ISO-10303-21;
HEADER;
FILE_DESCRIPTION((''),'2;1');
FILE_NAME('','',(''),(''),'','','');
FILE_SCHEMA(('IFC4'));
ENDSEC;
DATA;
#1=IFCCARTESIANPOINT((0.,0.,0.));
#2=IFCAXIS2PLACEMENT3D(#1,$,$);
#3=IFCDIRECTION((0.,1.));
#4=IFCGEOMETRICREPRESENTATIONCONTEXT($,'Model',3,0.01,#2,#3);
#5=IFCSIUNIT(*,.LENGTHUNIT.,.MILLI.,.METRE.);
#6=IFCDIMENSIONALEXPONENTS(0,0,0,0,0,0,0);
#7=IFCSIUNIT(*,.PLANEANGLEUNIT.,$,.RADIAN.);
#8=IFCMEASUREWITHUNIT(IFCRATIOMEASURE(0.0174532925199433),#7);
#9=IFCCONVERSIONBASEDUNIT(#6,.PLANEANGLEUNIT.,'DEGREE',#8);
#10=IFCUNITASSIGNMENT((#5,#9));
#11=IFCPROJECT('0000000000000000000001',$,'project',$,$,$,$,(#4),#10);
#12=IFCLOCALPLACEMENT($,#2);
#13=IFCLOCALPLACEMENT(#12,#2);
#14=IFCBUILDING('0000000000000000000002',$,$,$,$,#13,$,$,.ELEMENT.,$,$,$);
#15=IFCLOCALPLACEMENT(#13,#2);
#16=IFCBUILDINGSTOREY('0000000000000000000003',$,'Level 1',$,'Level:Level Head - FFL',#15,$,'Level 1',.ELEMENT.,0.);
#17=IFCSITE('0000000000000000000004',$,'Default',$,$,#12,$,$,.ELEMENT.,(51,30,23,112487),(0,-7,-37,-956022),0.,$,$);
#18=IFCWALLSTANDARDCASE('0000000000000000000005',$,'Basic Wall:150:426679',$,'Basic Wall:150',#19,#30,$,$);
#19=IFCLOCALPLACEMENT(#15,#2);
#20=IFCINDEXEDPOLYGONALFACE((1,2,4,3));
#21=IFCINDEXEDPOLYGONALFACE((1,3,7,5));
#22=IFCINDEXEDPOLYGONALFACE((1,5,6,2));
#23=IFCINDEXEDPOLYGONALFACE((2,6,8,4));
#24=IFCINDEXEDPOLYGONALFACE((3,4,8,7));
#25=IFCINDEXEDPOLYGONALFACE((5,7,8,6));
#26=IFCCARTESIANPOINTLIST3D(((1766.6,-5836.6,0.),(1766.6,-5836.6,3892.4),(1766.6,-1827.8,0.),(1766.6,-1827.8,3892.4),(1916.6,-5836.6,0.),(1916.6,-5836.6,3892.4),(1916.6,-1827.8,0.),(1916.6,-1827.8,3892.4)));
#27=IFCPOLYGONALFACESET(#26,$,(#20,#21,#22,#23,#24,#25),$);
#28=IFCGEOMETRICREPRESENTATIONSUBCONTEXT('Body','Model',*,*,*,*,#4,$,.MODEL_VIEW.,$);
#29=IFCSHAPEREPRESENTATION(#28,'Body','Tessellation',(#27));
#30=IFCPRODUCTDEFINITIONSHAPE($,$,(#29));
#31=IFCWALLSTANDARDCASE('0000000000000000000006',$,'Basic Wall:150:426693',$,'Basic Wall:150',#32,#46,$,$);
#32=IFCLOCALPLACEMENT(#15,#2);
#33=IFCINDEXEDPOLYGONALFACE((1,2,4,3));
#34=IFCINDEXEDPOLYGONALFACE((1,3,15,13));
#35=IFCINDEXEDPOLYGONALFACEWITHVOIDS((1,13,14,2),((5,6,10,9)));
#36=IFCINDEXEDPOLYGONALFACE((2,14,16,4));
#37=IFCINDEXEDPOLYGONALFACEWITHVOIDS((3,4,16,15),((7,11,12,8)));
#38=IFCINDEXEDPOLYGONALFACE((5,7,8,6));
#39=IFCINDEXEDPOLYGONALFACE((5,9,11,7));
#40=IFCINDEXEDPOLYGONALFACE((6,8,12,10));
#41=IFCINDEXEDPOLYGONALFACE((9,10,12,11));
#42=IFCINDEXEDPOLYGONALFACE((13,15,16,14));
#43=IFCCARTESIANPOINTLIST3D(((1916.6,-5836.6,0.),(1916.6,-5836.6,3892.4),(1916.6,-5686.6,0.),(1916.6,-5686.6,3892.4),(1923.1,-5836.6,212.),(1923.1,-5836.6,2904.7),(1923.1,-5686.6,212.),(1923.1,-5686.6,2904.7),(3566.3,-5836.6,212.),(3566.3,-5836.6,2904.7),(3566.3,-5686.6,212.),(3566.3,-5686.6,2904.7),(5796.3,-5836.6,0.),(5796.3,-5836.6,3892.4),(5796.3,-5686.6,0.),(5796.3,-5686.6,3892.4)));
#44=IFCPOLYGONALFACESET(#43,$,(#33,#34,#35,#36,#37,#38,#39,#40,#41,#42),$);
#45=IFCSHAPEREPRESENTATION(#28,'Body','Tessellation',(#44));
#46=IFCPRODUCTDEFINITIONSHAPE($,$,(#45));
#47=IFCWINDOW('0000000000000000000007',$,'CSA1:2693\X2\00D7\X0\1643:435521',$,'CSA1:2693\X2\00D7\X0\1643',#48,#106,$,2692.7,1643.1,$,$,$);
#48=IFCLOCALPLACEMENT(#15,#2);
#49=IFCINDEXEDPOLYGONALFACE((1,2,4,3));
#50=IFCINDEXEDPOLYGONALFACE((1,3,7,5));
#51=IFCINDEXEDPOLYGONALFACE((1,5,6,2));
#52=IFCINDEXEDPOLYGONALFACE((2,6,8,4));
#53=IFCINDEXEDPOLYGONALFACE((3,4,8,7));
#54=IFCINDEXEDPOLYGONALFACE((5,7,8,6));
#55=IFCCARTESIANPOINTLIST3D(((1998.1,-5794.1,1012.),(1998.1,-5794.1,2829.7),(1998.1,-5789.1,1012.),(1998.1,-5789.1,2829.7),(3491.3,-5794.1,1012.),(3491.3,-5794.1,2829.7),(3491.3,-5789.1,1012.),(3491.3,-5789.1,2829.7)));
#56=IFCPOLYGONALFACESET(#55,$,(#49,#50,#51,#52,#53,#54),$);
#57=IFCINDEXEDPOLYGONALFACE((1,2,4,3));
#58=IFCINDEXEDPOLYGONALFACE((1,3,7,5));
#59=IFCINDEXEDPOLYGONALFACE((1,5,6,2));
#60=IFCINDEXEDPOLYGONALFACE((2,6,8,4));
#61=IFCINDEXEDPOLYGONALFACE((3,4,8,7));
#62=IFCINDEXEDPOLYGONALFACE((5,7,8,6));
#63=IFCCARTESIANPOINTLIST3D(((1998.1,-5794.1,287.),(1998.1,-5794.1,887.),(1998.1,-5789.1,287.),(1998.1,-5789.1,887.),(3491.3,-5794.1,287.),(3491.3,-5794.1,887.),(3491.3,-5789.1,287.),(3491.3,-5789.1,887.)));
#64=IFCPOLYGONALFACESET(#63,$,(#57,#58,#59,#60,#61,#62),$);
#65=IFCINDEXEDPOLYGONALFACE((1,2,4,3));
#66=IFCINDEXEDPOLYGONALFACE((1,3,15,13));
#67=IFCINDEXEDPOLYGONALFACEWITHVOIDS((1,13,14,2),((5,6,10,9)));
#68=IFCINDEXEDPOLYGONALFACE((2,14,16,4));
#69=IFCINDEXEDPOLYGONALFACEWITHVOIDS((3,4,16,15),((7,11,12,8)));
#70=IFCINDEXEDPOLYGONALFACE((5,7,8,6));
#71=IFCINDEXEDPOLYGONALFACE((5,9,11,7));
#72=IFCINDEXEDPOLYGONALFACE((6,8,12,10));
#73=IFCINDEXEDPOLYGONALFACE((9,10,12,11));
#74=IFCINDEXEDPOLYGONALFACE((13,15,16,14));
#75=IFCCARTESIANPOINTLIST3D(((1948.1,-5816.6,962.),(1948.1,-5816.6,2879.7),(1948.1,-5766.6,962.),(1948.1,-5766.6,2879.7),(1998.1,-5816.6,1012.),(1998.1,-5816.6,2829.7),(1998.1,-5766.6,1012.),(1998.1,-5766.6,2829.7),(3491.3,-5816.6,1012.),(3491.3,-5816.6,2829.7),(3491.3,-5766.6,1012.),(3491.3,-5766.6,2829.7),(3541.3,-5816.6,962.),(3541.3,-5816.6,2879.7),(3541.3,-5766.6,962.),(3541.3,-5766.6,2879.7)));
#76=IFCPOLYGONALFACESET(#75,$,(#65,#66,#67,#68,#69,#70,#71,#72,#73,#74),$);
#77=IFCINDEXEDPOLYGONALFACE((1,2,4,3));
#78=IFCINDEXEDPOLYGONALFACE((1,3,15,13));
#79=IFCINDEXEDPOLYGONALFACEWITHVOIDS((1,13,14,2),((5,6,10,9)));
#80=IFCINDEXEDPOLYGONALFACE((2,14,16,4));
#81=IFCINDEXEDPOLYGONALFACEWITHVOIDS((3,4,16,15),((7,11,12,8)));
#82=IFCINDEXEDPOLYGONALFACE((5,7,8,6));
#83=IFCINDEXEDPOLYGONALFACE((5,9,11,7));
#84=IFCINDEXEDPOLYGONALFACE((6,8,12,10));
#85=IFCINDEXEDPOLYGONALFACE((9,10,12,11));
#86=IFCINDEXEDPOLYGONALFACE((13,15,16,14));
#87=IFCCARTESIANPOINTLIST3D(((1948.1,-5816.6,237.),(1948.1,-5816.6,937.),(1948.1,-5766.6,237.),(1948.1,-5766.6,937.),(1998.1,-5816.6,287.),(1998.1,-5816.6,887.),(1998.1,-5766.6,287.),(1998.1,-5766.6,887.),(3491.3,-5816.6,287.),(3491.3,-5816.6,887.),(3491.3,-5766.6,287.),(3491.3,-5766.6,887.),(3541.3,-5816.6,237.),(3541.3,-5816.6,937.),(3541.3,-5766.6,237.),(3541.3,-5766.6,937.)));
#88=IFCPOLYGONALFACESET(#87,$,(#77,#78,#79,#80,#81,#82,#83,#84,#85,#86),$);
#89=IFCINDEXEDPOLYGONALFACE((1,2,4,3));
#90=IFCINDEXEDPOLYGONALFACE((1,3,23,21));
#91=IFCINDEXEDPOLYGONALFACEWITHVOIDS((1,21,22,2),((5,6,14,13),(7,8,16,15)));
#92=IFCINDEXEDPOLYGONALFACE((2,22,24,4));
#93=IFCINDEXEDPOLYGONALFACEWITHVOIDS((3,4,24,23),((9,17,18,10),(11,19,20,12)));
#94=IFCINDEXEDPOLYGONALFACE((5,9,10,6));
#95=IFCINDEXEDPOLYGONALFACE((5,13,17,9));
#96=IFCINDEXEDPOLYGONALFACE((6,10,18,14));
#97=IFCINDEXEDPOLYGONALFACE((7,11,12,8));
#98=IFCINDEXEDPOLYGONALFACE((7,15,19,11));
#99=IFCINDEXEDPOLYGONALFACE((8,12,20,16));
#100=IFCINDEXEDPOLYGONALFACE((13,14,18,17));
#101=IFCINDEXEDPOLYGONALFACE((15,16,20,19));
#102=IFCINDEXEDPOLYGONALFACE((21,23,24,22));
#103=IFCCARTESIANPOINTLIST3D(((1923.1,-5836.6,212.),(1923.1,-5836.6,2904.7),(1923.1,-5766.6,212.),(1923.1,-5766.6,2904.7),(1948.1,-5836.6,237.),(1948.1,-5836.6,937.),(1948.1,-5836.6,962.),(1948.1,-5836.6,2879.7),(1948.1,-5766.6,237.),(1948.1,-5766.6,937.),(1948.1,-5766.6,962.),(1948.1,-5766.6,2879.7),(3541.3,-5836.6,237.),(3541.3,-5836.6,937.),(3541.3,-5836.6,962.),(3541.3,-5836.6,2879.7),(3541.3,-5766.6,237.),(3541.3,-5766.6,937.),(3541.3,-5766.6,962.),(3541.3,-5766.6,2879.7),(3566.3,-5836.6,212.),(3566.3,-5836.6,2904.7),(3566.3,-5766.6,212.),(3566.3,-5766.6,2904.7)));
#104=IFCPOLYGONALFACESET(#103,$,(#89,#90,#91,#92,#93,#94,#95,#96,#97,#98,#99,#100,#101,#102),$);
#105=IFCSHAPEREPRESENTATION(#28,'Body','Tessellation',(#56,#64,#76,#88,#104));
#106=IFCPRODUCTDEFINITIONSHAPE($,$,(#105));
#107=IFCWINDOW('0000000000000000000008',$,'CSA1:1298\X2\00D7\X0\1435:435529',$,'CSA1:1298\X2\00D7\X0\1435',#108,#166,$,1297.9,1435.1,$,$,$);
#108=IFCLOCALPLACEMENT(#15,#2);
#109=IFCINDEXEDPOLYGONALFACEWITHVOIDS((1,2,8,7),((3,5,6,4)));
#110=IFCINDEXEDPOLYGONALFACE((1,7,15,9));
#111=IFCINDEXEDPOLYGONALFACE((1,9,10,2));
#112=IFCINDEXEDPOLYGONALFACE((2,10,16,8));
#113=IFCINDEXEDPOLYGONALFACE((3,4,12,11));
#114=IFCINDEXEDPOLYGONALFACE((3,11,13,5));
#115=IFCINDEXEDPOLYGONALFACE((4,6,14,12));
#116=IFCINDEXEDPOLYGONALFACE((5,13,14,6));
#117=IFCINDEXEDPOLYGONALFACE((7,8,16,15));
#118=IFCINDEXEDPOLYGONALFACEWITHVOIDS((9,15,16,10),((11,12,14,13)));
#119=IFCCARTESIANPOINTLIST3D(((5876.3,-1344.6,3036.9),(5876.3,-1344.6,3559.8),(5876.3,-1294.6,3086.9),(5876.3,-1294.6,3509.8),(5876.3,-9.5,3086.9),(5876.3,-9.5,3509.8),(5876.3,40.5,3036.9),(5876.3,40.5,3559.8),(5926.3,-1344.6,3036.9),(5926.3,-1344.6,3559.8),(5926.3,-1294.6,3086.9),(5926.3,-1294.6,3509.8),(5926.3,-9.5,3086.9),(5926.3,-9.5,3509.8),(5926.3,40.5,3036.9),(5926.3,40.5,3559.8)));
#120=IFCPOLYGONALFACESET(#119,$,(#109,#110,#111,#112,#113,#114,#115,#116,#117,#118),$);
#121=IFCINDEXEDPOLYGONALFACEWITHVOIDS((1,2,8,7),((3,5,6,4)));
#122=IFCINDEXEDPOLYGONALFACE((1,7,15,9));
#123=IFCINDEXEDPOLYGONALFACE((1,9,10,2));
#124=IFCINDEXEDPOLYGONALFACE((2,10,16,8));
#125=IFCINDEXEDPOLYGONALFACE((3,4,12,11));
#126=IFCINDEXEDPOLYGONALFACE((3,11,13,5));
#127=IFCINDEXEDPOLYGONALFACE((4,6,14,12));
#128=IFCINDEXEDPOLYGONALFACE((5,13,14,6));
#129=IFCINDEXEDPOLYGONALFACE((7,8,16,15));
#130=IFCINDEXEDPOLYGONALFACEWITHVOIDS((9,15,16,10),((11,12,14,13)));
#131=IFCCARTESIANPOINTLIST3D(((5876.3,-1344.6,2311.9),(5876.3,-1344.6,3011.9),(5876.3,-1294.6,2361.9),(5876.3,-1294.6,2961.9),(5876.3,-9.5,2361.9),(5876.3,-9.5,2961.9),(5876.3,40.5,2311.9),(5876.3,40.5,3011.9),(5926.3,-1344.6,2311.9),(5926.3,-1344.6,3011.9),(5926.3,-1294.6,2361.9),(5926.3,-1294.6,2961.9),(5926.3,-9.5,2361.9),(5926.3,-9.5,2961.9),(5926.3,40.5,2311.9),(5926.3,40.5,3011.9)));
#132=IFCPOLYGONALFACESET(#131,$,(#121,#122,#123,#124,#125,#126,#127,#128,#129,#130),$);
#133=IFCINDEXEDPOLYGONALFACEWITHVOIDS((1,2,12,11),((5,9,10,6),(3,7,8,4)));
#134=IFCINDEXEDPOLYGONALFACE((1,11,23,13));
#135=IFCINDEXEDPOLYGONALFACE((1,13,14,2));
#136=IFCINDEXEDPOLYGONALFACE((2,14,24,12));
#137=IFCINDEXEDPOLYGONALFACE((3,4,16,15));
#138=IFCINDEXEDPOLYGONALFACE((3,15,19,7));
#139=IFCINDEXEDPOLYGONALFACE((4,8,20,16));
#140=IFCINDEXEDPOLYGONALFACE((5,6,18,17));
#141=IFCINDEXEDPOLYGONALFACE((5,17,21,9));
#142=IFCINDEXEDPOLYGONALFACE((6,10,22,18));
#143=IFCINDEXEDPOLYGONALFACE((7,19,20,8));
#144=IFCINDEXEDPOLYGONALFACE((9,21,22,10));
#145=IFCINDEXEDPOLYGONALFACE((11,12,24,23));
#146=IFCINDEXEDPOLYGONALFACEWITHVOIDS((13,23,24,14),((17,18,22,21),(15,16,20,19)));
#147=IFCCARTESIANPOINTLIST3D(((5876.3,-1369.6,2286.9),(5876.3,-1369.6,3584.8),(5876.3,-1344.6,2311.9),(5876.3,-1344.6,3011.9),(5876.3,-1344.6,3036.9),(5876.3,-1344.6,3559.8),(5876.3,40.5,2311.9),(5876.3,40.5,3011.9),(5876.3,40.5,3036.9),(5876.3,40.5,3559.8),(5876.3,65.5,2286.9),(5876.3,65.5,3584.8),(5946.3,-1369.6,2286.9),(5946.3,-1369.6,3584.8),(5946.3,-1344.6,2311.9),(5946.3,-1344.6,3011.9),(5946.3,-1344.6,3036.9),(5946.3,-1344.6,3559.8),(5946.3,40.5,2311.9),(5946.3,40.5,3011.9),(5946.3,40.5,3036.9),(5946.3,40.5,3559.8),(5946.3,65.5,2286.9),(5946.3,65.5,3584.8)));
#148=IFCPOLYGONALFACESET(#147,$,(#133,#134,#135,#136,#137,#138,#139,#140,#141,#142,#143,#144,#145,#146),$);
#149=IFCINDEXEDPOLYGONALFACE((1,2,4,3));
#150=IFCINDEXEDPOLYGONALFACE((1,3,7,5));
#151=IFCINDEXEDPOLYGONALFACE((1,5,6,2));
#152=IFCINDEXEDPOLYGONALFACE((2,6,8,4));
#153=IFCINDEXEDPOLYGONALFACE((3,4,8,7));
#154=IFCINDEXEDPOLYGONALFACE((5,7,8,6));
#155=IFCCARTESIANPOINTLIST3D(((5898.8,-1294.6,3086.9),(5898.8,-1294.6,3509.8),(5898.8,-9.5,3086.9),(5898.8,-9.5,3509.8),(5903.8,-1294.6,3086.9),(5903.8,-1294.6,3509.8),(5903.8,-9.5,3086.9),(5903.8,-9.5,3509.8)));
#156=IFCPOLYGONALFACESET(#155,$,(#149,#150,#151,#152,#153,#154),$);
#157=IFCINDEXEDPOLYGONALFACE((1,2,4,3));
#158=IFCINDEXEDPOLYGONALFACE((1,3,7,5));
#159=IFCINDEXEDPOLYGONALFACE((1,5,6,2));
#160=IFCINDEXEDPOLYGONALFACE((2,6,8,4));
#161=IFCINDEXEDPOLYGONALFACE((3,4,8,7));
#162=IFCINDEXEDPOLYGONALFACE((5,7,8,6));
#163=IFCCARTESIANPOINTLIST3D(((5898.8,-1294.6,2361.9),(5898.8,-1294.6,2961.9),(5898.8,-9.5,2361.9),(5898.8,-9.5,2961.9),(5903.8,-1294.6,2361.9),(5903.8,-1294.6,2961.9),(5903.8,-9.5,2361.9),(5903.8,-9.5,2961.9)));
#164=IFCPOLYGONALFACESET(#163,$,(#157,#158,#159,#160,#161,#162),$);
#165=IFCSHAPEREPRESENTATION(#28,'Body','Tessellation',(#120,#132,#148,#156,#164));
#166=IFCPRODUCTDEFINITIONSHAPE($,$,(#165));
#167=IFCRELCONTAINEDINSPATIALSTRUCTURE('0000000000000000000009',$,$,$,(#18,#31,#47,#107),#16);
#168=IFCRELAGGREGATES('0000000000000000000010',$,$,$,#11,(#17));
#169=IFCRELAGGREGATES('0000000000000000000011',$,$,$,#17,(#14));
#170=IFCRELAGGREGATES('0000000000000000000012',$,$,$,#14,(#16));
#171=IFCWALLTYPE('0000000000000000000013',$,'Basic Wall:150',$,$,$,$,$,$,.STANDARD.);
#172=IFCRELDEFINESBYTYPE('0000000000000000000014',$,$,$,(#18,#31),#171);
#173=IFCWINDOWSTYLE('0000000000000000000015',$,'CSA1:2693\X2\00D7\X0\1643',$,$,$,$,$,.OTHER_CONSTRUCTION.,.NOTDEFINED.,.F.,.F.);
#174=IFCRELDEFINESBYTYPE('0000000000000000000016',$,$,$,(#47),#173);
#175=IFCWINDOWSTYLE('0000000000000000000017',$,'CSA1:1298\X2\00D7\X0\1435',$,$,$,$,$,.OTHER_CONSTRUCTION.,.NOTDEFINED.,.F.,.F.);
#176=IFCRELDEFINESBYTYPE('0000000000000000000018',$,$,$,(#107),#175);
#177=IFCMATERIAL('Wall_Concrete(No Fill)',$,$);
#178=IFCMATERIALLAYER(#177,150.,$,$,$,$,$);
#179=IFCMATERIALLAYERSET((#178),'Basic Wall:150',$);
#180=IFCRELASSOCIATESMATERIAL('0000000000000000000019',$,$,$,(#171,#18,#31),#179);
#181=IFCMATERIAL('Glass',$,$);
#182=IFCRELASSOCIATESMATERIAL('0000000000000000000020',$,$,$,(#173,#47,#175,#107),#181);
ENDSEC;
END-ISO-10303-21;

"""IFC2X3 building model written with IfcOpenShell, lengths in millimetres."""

from ifc_helpers import new_model, entity, si_unit, converted_unit, direction, frame, frame_2d, origin, origin_2d_with_axis, place, context, subcontext, project, spatial, polyline, rectangle, outline, extrude, source, transform, mapped, material, layer, layer_set, layer_usage, type_object, type_shapes, element, save


model = new_model("IFC2X3")

# Units and contexts
model_context = context("Model", 3, precision=0.01, world=origin(), true_north=direction((0.0, 1.0)))
body_context = subcontext(model_context, "Body", "Model", "MODEL_VIEW")
ifc_project = project(units=[si_unit("LENGTHUNIT", "METRE", prefix="MILLI"), converted_unit("PLANEANGLEUNIT", "DEGREE", entity("IfcRatioMeasure", 0.0174532925199433), si_unit("PLANEANGLEUNIT", "RADIAN"), dimensions=[0, 0, 0, 0, 0, 0, 0])], contexts=[model_context])

# Site, building, storey
site_placement = place(None, origin())
site = spatial("IfcSite", under=ifc_project, at=site_placement, Name="Default", CompositionType="ELEMENT", RefLatitude=(51, 30, 23, 112487), RefLongitude=(0, -7, -37, -956022), RefElevation=0.0)
building_placement = place(site_placement, origin())
building = spatial("IfcBuilding", under=site, at=building_placement, CompositionType="ELEMENT")
storey_placement = place(building_placement, origin())
storey = spatial("IfcBuildingStorey", under=building, at=storey_placement, Name="Level 1", ObjectType="Level:Level Head - FFL", LongName="Level 1", CompositionType="ELEMENT", Elevation=0.0)

# Wall
ifc_material_1 = material(Name="Wall_Concrete(No Fill)")
ifc_layer = layer(ifc_material_1, 150.0)
ifc_layer_set = layer_set([ifc_layer], Name="Basic Wall:150")
ifc_layer_usage_1 = layer_usage(ifc_layer_set, "AXIS2", "NEGATIVE", 75.0)
wall_type = type_object("IfcWallType", Name="Basic Wall:150", PredefinedType="STANDARD", material=ifc_layer_set)
wall_1_placement = place(storey_placement, frame((1841.6, -5836.6, 0.0), z_axis=(0.0, 0.0, 1.0), x_axis=(0.0, 1.0, 0.0)))
element("IfcWallStandardCase", 1, at=wall_1_placement, inside=storey, type_object=wall_type, material=ifc_layer_usage_1, Name="Basic Wall:150:426679", ObjectType="Basic Wall:150", context=body_context, shape_type="SweptSolid", body=[
    extrude(rectangle(XDim=4008.8, YDim=150.0, at=frame_2d((2004.4, 0.0), x_axis=(-1.0, 0.0))), origin(), (0.0, 0.0, 1.0), 3892.4),
])

# Wall, opening
ifc_layer_usage_2 = layer_usage(ifc_layer_set, "AXIS2", "NEGATIVE", 75.0)
wall_2_placement = place(storey_placement, frame((1916.6, -5761.6, 0.0)))
wall_2 = element("IfcWallStandardCase", 2, at=wall_2_placement, inside=storey, type_object=wall_type, material=ifc_layer_usage_2, Name="Basic Wall:150:426693", ObjectType="Basic Wall:150", context=body_context, shape_type="SweptSolid", body=[
    extrude(rectangle(XDim=3879.7, YDim=150.0, at=frame_2d((1939.9, 0.0), x_axis=(-1.0, 0.0))), origin(), (0.0, 0.0, 1.0), 3892.4),
])
opening_1_placement = place(wall_2_placement, origin())
element("IfcOpeningElement", 3, at=opening_1_placement, cuts=wall_2, ObjectType="Opening", context=body_context, shape_type="SweptSolid", body=[
    extrude(rectangle(XDim=2692.7, YDim=1643.1, at=frame_2d((0.0, 0.0), x_axis=(1.0, 0.0))), frame((828.1, -75.0, 1558.4), z_axis=(0.0, 1.0, 0.0), x_axis=(0.0, 0.0, -1.0)), (0.0, 0.0, 1.0), 150.0),
])

# Windows
ifc_material_2 = material(Name="Glass")
window_style_1 = type_object("IfcWindowStyle", Name="CSA1:2693×1643", ConstructionType="OTHER_CONSTRUCTION", OperationType="NOTDEFINED", ParameterTakesPrecedence=False, Sizeable=False, material=ifc_material_2)
shared_shape_1 = source(origin(), body_context, "Body", "SweptSolid", [
    extrude(rectangle(XDim=5.0, YDim=1493.1, at=origin_2d_with_axis()), frame((821.6, 45.0, 800.0), z_axis=(0.0, 0.0, 1.0), x_axis=(0.0, 1.0, 0.0)), (0.0, 0.0, 1.0), 1817.7),
    extrude(rectangle(XDim=5.0, YDim=1493.1, at=origin_2d_with_axis()), frame((821.6, 45.0, 75.0), z_axis=(0.0, 0.0, 1.0), x_axis=(0.0, 1.0, 0.0)), (0.0, 0.0, 1.0), 600.0),
    extrude(outline(polyline([(-796.6, -958.8), (796.6, -958.8), (796.6, 958.8), (-796.6, 958.8), (-796.6, -958.8)]), holes=[polyline([(-746.6, -908.8), (-746.6, 908.8), (746.6, 908.8), (746.6, -908.8), (-746.6, -908.8)])]), frame((821.6, 20.0, 1708.8), z_axis=(0.0, 1.0, 0.0), x_axis=(1.0, 0.0, 0.0)), (0.0, 0.0, 1.0), 50.0),
    extrude(outline(polyline([(-796.6, -350.0), (796.6, -350.0), (796.6, 350.0), (-796.6, 350.0), (-796.6, -350.0)]), holes=[polyline([(-746.6, -300.0), (-746.6, 300.0), (746.6, 300.0), (746.6, -300.0), (-746.6, -300.0)])]), frame((821.6, 20.0, 375.0), z_axis=(0.0, 1.0, 0.0), x_axis=(1.0, 0.0, 0.0)), (0.0, 0.0, 1.0), 50.0),
    extrude(outline(polyline([(-821.6, -1346.3), (821.6, -1346.3), (821.6, 1346.3), (-821.6, 1346.3), (-821.6, -1346.3)]), holes=[polyline([(-796.6, -1321.3), (-796.6, 596.3), (796.6, 596.3), (796.6, -1321.3), (-796.6, -1321.3)]), polyline([(-796.6, 621.3), (-796.6, 1321.3), (796.6, 1321.3), (796.6, 621.3), (-796.6, 621.3)])]), frame((821.6, 0.0, 1346.3), z_axis=(0.0, 1.0, 0.0), x_axis=(1.0, 0.0, 0.0)), (0.0, 0.0, 1.0), 70.0),
])
type_shapes(window_style_1, [shared_shape_1])
window_1_placement = place(storey_placement, frame((1923.1, -5836.6, 212.0)))
element("IfcWindow", 4, at=window_1_placement, inside=storey, type_object=window_style_1, material=ifc_material_2, Name="CSA1:2693×1643:435521", ObjectType="CSA1:2693×1643", OverallHeight=2692.7, OverallWidth=1643.1, context=body_context, shape_type="MappedRepresentation", body=[
    mapped(shared_shape_1, transform((0.0, 0.0, 0.0), scale=1.0)),
])
window_style_2 = type_object("IfcWindowStyle", Name="CSA1:1298×1435", ConstructionType="OTHER_CONSTRUCTION", OperationType="NOTDEFINED", ParameterTakesPrecedence=False, Sizeable=False, material=ifc_material_2)
shared_shape_2 = source(origin(), body_context, "Body", "SweptSolid", [
    extrude(outline(polyline([(-692.5, -261.4), (692.5, -261.4), (692.5, 261.4), (-692.5, 261.4), (-692.5, -261.4)]), holes=[polyline([(-642.5, -211.4), (-642.5, 211.4), (642.5, 211.4), (642.5, -211.4), (-642.5, -211.4)])]), frame((717.5, 20.0, 1011.4), z_axis=(0.0, 1.0, 0.0), x_axis=(1.0, 0.0, 0.0)), (0.0, 0.0, 1.0), 50.0),
    extrude(outline(polyline([(-692.5, -350.0), (692.5, -350.0), (692.5, 350.0), (-692.5, 350.0), (-692.5, -350.0)]), holes=[polyline([(-642.5, -300.0), (-642.5, 300.0), (642.5, 300.0), (642.5, -300.0), (-642.5, -300.0)])]), frame((717.5, 20.0, 375.0), z_axis=(0.0, 1.0, 0.0), x_axis=(1.0, 0.0, 0.0)), (0.0, 0.0, 1.0), 50.0),
    extrude(outline(polyline([(-717.5, -648.9), (717.5, -648.9), (717.5, 648.9), (-717.5, 648.9), (-717.5, -648.9)]), holes=[polyline([(-692.5, -623.9), (-692.5, -101.1), (692.5, -101.1), (692.5, -623.9), (-692.5, -623.9)]), polyline([(-692.5, -76.1), (-692.5, 623.9), (692.5, 623.9), (692.5, -76.1), (-692.5, -76.1)])]), frame((717.5, 0.0, 648.9), z_axis=(0.0, 1.0, 0.0), x_axis=(1.0, 0.0, 0.0)), (0.0, 0.0, 1.0), 70.0),
    extrude(rectangle(XDim=5.0, YDim=1285.1, at=frame_2d((0.0, 0.0), x_axis=(1.0, 0.0))), frame((717.5, 45.0, 800.0), z_axis=(0.0, 0.0, 1.0), x_axis=(0.0, 1.0, 0.0)), (0.0, 0.0, 1.0), 422.9),
    extrude(rectangle(XDim=5.0, YDim=1285.1, at=frame_2d((0.0, 0.0), x_axis=(1.0, 0.0))), frame((717.5, 45.0, 75.0), z_axis=(0.0, 0.0, 1.0), x_axis=(0.0, 1.0, 0.0)), (0.0, 0.0, 1.0), 600.0),
])
type_shapes(window_style_2, [shared_shape_2])
window_2_placement = place(storey_placement, frame((5946.3, -1369.6, 2286.9), z_axis=(0.0, 0.0, 1.0), x_axis=(0.0, 1.0, 0.0)))
element("IfcWindow", 5, at=window_2_placement, inside=storey, type_object=window_style_2, material=ifc_material_2, Name="CSA1:1298×1435:435529", ObjectType="CSA1:1298×1435", OverallHeight=1297.9, OverallWidth=1435.1, context=body_context, shape_type="MappedRepresentation", body=[
    mapped(shared_shape_2, transform((0.0, 0.0, 0.0), scale=1.0)),
])

save(model, "model.ifc")
